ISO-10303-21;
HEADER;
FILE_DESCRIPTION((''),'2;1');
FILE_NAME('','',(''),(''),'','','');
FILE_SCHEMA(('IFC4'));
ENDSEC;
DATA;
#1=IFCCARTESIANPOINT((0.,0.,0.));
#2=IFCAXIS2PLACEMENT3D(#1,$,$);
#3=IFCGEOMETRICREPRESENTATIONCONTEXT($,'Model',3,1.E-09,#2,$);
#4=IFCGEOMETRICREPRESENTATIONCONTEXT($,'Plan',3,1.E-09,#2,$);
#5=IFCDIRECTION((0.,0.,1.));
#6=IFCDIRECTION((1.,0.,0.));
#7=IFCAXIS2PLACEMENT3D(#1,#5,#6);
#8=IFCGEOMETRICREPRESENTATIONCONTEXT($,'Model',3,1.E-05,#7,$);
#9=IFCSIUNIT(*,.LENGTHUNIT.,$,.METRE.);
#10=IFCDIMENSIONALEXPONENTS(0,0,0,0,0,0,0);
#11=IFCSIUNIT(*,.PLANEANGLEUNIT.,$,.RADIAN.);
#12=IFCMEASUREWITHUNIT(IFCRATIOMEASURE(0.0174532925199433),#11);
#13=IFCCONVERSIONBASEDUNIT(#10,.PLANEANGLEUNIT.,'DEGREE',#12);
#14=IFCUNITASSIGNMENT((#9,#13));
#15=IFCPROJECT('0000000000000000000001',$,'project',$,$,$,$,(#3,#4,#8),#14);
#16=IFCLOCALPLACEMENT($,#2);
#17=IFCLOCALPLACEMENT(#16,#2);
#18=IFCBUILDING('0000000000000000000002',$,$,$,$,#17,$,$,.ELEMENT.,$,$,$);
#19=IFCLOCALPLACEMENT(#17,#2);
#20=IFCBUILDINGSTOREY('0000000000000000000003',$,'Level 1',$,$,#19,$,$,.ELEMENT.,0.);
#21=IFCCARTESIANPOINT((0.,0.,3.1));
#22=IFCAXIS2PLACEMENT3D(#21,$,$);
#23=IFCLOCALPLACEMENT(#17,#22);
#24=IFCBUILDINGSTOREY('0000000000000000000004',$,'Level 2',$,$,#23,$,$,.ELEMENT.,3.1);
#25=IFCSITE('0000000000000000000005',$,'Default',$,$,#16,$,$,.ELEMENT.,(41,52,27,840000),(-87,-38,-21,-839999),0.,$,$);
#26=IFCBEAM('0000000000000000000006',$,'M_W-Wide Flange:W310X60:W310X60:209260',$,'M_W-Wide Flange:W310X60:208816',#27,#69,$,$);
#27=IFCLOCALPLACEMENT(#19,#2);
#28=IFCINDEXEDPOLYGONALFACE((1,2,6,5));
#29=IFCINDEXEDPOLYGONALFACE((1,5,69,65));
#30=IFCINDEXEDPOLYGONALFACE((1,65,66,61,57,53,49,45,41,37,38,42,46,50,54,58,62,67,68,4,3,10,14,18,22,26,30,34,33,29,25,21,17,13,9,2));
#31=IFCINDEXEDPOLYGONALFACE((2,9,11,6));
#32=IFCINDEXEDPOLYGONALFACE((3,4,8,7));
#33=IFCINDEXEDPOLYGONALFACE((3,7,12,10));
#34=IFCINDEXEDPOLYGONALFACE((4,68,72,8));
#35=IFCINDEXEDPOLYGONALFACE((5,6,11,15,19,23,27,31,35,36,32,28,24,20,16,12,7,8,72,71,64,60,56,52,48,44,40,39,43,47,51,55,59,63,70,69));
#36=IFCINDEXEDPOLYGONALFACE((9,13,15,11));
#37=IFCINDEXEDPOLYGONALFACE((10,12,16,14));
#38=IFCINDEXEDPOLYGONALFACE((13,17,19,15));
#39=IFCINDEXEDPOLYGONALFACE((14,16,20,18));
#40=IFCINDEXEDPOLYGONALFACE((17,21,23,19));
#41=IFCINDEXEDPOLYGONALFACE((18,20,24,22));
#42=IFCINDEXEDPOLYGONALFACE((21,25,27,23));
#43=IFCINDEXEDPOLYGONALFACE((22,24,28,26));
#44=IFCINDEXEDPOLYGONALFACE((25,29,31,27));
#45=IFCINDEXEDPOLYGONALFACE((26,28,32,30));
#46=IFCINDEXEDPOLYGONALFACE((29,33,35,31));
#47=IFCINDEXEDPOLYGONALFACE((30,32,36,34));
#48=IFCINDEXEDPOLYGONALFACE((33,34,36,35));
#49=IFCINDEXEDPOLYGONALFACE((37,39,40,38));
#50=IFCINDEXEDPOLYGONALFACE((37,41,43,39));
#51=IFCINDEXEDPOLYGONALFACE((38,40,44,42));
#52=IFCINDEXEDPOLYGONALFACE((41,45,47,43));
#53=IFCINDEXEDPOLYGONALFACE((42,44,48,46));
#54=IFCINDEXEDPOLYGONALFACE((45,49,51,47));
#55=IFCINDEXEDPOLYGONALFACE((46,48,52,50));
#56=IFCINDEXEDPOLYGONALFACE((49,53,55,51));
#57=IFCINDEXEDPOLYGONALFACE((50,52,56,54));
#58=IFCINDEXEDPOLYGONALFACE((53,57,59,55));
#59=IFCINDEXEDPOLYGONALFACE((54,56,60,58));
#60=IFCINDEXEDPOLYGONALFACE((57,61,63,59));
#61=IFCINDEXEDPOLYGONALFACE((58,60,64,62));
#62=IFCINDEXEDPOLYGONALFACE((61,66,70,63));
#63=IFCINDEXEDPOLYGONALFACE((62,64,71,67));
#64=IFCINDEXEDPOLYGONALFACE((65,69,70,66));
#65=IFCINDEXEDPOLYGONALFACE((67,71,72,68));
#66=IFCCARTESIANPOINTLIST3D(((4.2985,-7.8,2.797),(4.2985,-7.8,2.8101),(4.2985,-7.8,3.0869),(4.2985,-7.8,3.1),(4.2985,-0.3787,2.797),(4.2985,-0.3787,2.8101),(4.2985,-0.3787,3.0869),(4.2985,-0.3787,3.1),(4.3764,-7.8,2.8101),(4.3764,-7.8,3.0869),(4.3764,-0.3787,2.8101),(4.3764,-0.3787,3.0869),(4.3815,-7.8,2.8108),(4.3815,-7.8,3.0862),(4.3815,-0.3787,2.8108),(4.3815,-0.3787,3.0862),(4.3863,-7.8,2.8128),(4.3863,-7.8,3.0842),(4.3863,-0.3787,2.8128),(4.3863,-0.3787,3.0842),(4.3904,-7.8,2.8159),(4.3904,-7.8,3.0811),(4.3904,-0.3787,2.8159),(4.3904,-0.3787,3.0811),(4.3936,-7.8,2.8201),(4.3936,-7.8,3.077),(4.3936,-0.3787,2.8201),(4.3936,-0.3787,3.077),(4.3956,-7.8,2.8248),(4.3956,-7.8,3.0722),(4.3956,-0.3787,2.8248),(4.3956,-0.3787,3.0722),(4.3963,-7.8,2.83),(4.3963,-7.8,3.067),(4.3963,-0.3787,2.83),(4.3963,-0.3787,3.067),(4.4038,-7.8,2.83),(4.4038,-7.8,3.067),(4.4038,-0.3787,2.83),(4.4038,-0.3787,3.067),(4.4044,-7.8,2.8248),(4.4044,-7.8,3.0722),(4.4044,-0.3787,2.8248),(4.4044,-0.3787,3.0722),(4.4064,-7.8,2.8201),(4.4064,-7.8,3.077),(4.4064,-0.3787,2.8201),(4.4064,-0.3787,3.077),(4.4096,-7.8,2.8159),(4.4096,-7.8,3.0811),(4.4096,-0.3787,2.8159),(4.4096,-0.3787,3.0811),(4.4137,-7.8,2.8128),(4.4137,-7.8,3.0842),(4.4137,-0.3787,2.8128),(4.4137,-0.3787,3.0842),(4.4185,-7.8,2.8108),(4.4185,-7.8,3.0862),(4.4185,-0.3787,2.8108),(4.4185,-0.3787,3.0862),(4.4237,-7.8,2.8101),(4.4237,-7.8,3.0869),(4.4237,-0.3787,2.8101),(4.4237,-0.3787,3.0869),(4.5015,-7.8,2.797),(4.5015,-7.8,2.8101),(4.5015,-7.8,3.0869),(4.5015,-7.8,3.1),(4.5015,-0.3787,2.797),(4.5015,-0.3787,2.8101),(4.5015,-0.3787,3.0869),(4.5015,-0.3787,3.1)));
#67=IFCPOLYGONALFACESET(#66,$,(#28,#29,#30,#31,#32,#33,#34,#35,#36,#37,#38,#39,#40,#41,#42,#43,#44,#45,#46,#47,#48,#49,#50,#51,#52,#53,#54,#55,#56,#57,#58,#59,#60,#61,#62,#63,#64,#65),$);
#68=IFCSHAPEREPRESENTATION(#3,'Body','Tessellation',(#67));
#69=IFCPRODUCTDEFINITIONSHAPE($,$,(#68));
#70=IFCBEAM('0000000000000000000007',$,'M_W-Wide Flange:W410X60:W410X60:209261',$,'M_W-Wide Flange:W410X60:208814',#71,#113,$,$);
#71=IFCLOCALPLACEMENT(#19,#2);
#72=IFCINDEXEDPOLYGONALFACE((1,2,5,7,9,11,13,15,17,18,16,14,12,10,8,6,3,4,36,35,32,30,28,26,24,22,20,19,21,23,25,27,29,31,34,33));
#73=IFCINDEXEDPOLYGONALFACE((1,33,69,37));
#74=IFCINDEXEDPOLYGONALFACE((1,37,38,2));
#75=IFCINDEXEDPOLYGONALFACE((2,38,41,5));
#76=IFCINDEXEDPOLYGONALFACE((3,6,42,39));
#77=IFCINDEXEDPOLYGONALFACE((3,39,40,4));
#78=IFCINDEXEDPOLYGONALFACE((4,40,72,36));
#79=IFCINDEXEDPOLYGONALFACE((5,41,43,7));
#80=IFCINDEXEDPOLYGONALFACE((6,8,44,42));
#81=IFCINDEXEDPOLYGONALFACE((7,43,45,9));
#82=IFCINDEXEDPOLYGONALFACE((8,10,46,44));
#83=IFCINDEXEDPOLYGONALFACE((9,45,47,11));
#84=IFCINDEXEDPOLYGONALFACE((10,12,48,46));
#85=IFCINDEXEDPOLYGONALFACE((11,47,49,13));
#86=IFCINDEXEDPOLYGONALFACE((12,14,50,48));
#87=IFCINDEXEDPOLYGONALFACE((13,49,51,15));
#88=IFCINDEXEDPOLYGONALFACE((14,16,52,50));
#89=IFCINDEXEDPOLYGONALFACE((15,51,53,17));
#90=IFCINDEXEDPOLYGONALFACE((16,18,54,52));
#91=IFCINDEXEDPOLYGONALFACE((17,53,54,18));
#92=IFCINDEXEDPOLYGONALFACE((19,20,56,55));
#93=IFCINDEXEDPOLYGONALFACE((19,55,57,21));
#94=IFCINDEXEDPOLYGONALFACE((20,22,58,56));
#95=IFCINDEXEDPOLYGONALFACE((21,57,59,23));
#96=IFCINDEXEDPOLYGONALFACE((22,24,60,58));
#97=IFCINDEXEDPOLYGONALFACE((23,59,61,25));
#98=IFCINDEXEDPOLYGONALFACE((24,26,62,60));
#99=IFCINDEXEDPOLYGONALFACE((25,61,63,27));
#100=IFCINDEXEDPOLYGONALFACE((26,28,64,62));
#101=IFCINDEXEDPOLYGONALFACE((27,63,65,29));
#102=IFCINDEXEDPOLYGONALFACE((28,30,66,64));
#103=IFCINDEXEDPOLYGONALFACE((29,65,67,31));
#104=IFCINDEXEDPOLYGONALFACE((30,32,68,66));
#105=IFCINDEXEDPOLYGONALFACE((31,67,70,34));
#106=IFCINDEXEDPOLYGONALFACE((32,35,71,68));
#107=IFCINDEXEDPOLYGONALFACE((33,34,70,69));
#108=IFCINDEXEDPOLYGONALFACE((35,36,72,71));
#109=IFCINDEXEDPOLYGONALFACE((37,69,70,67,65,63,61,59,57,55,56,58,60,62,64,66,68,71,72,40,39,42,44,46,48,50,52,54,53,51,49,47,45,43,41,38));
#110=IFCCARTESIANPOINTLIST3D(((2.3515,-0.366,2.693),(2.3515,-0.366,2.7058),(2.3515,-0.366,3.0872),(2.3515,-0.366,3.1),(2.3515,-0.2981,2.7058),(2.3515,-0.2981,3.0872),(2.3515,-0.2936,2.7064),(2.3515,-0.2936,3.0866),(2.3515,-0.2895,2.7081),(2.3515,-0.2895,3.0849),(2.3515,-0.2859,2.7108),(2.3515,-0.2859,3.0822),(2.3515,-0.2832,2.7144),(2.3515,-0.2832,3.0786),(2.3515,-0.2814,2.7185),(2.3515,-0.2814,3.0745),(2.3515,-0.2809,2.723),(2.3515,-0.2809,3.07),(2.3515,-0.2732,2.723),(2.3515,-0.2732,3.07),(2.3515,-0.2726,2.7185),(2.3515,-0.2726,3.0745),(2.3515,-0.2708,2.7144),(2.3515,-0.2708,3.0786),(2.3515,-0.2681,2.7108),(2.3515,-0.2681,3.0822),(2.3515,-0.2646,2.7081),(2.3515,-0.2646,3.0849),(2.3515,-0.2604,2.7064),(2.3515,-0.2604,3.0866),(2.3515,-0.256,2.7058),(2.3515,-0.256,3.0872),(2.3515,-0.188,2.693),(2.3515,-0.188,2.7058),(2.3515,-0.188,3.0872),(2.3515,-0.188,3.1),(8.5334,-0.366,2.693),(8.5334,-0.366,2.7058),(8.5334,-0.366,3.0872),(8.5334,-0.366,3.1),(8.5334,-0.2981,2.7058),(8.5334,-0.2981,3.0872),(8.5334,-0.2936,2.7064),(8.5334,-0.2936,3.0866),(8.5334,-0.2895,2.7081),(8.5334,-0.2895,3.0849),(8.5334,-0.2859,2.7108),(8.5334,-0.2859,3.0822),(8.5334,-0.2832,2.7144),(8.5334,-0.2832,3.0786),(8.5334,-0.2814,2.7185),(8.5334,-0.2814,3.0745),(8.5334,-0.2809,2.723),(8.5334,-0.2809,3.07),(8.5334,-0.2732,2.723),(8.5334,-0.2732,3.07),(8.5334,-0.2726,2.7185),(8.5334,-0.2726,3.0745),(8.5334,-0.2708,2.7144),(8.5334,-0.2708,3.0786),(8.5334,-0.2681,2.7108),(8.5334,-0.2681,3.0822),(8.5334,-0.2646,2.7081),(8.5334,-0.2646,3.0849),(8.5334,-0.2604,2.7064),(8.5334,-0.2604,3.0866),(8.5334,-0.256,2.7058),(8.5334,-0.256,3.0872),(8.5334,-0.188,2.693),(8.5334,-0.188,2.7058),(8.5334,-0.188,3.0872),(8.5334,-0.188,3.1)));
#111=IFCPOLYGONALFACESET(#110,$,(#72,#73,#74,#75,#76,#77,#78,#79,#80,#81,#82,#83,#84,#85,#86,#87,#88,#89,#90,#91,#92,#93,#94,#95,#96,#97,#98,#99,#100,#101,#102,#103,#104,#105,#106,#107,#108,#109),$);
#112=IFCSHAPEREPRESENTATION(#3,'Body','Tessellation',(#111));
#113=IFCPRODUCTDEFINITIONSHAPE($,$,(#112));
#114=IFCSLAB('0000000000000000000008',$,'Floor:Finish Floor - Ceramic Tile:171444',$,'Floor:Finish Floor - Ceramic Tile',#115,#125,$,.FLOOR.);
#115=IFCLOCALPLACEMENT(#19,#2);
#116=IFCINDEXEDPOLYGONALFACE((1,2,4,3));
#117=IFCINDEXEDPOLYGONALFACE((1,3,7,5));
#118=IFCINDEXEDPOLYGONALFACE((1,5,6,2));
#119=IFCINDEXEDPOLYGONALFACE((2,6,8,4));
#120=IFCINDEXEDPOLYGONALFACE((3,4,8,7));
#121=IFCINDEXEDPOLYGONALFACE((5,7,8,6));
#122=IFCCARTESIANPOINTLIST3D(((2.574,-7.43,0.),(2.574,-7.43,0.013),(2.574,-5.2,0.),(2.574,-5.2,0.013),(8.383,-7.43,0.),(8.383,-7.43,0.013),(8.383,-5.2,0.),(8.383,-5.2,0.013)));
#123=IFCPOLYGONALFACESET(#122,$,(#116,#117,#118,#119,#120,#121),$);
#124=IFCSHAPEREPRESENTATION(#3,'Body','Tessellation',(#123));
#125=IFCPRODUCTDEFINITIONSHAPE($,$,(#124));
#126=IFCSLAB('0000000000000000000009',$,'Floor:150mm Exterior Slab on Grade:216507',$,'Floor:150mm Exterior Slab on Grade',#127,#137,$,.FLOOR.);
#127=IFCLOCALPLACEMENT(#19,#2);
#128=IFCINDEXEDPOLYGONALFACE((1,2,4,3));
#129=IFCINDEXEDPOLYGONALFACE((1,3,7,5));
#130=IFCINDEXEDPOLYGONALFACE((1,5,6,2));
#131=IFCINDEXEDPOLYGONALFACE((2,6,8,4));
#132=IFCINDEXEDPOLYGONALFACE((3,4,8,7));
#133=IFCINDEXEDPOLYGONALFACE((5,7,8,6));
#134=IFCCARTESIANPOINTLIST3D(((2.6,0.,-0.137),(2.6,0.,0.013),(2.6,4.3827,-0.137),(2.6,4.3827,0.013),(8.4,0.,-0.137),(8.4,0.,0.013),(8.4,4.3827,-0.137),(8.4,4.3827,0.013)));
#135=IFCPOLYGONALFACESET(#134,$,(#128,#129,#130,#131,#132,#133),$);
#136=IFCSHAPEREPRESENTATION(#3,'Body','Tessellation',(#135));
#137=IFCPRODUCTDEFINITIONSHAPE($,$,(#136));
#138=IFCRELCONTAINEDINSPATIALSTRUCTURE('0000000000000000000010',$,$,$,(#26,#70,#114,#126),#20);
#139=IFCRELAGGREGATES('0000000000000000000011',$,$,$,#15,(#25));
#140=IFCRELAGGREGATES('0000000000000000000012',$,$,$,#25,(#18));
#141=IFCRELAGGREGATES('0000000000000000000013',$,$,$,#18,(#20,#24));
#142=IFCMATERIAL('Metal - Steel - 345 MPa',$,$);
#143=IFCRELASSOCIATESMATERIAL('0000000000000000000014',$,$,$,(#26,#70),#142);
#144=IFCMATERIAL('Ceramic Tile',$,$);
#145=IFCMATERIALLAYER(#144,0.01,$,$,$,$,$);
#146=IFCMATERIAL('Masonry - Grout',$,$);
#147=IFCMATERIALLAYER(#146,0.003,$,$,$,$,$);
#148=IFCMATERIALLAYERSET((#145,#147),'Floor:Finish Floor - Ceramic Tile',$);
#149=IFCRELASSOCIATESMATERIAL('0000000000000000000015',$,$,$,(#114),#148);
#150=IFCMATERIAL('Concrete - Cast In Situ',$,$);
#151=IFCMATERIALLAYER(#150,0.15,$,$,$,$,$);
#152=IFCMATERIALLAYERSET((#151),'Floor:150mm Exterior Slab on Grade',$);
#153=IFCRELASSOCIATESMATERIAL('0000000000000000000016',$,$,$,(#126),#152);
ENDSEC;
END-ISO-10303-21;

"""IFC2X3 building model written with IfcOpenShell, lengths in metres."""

from ifc_helpers import new_model, entity, si_unit, converted_unit, frame, frame_2d, origin, origin_with_axes, place, context, project, spatial, polyline, circle_curve, parameter, trimmed, segment, composite_curve, rectangle, outline, extrude, material, layer, layer_set, layer_usage, element, save


model = new_model("IFC2X3")

# Units and contexts
model_context_1 = context("Model", 3, precision=1e-09, world=origin())
plan_context = context("Plan", 3, precision=1e-09, world=origin())
model_context_2 = context("Model", 3, precision=1e-05, world=origin_with_axes())
ifc_project = project(units=[si_unit("LENGTHUNIT", "METRE"), converted_unit("PLANEANGLEUNIT", "DEGREE", entity("IfcRatioMeasure", 0.0174532925199433), si_unit("PLANEANGLEUNIT", "RADIAN"), dimensions=[0, 0, 0, 0, 0, 0, 0])], contexts=[model_context_1, plan_context, model_context_2])

# Site, building, storey
site_placement = place(None, origin())
site = spatial("IfcSite", under=ifc_project, at=site_placement, Name="Default", CompositionType="ELEMENT", RefLatitude=(41, 52, 27, 840000), RefLongitude=(-87, -38, -21, -839999), RefElevation=0.0)
building_placement = place(site_placement, origin())
building = spatial("IfcBuilding", under=site, at=building_placement, CompositionType="ELEMENT")
storey_1_placement = place(building_placement, origin())
storey_1 = spatial("IfcBuildingStorey", under=building, at=storey_1_placement, Name="Level 1", CompositionType="ELEMENT", Elevation=0.0)

# Beams
ifc_material_1 = material(Name="Metal - Steel - 345 MPa")
beam_1_placement = place(storey_1_placement, frame((4.4, -7.8, 3.1)))
element("IfcBeam", 1, at=beam_1_placement, inside=storey_1, material=ifc_material_1, Name="M_W-Wide Flange:W310X60:W310X60:209260", ObjectType="M_W-Wide Flange:W310X60:208816", context=model_context_1, shape_type="SweptSolid", body=[
    extrude(outline(composite_curve([segment(polyline([(-0.1015, -0.1384), (-0.1015, -0.1515)]), True, "CONTINUOUS"), segment(polyline([(-0.1015, -0.1515), (0.1015, -0.1515)]), True, "CONTINUOUS"), segment(polyline([(0.1015, -0.1515), (0.1015, -0.1384)]), True, "CONTINUOUS"), segment(polyline([(0.1015, -0.1384), (0.0236, -0.1384)]), True, "CONTINUOUS"), segment(trimmed(circle_curve(frame_2d((0.0236, -0.1185), x_axis=(1.0, 0.0)), 0.0199), [parameter(180.0)], [parameter(270.0)], True, "PARAMETER"), False, "CONTINUOUS"), segment(polyline([(0.0037, -0.1185), (0.0037, 0.1185)]), True, "CONTINUOUS"), segment(trimmed(circle_curve(frame_2d((0.0236, 0.1185), x_axis=(1.0, 0.0)), 0.0199), [parameter(90.0)], [parameter(180.0)], True, "PARAMETER"), False, "CONTINUOUS"), segment(polyline([(0.0236, 0.1384), (0.1015, 0.1384)]), True, "CONTINUOUS"), segment(polyline([(0.1015, 0.1384), (0.1015, 0.1515)]), True, "CONTINUOUS"), segment(polyline([(0.1015, 0.1515), (-0.1015, 0.1515)]), True, "CONTINUOUS"), segment(polyline([(-0.1015, 0.1515), (-0.1015, 0.1384)]), True, "CONTINUOUS"), segment(polyline([(-0.1015, 0.1384), (-0.0237, 0.1384)]), True, "CONTINUOUS"), segment(trimmed(circle_curve(frame_2d((-0.0237, 0.1185), x_axis=(1.0, 0.0)), 0.0199), [parameter(360.0)], [parameter(90.0)], True, "PARAMETER"), False, "CONTINUOUS"), segment(polyline([(-0.0038, 0.1185), (-0.0038, -0.1185)]), True, "CONTINUOUS"), segment(trimmed(circle_curve(frame_2d((-0.0237, -0.1185), x_axis=(1.0, 0.0)), 0.0199), [parameter(270.0)], [parameter(0.0)], True, "PARAMETER"), False, "CONTINUOUS"), segment(polyline([(-0.0237, -0.1384), (-0.1015, -0.1384)]), True, "CONTINUOUS")], self_intersect=False)), frame((0.0, 0.0, -0.1515), z_axis=(0.0, -1.0, 0.0), x_axis=(1.0, 0.0, 0.0)), (0.0, 0.0, -1.0), 7.4213),
])
beam_2_placement = place(storey_1_placement, frame((8.5915, -0.277, 3.1), z_axis=(0.0, 0.0, 1.0), x_axis=(0.0, 1.0, 0.0)))
element("IfcBeam", 2, at=beam_2_placement, inside=storey_1, material=ifc_material_1, Name="M_W-Wide Flange:W410X60:W410X60:209261", ObjectType="M_W-Wide Flange:W410X60:208814", context=model_context_1, shape_type="SweptSolid", body=[
    extrude(outline(composite_curve([segment(polyline([(0.1907, -0.089), (0.2035, -0.089)]), True, "CONTINUOUS"), segment(polyline([(0.2035, -0.089), (0.2035, 0.089)]), True, "CONTINUOUS"), segment(polyline([(0.2035, 0.089), (0.1907, 0.089)]), True, "CONTINUOUS"), segment(polyline([(0.1907, 0.089), (0.1907, 0.021)]), True, "CONTINUOUS"), segment(trimmed(circle_curve(frame_2d((0.1735, 0.021), x_axis=(1.0, 0.0)), 0.0172), [parameter(270.0)], [parameter(360.0)], True, "PARAMETER"), False, "CONTINUOUS"), segment(polyline([(0.1735, 0.0038), (-0.1735, 0.0038)]), True, "CONTINUOUS"), segment(trimmed(circle_curve(frame_2d((-0.1735, 0.021), x_axis=(0.0, -1.0)), 0.0172), [parameter(270.0)], [parameter(360.0)], True, "PARAMETER"), False, "CONTINUOUS"), segment(polyline([(-0.1907, 0.021), (-0.1907, 0.089)]), True, "CONTINUOUS"), segment(polyline([(-0.1907, 0.089), (-0.2035, 0.089)]), True, "CONTINUOUS"), segment(polyline([(-0.2035, 0.089), (-0.2035, -0.089)]), True, "CONTINUOUS"), segment(polyline([(-0.2035, -0.089), (-0.1907, -0.089)]), True, "CONTINUOUS"), segment(polyline([(-0.1907, -0.089), (-0.1907, -0.0211)]), True, "CONTINUOUS"), segment(trimmed(circle_curve(frame_2d((-0.1735, -0.0211), x_axis=(-1.0, 0.0)), 0.0172), [parameter(270.0)], [parameter(0.0)], True, "PARAMETER"), False, "CONTINUOUS"), segment(polyline([(-0.1735, -0.0039), (0.1735, -0.0039)]), True, "CONTINUOUS"), segment(trimmed(circle_curve(frame_2d((0.1735, -0.0211), x_axis=(0.0, 1.0)), 0.0172), [parameter(270.0)], [parameter(0.0)], True, "PARAMETER"), False, "CONTINUOUS"), segment(polyline([(0.1907, -0.0211), (0.1907, -0.089)]), True, "CONTINUOUS")], self_intersect=False)), frame((0.0, 6.24, -0.2035), z_axis=(0.0, -1.0, 0.0), x_axis=(0.0, 0.0, -1.0)), (0.0, 0.0, 1.0), 6.1819),
])

# Slabs
ifc_material_2 = material(Name="Ceramic Tile")
ifc_layer_1 = layer(ifc_material_2, 0.01)
ifc_material_3 = material(Name="Masonry - Grout")
ifc_layer_2 = layer(ifc_material_3, 0.003)
ifc_layer_set_1 = layer_set([ifc_layer_1, ifc_layer_2], Name="Floor:Finish Floor - Ceramic Tile")
ifc_layer_usage_1 = layer_usage(ifc_layer_set_1, "AXIS3", "POSITIVE", 0.0)
slab_1_placement = place(storey_1_placement, frame((2.574, -7.43, 0.0)))
element("IfcSlab", 3, at=slab_1_placement, inside=storey_1, material=ifc_layer_usage_1, Name="Floor:Finish Floor - Ceramic Tile:171444", ObjectType="Floor:Finish Floor - Ceramic Tile", PredefinedType="FLOOR", context=model_context_1, shape_type="SweptSolid", body=[
    extrude(rectangle(XDim=5.809, YDim=2.23, at=frame_2d((0.0, 0.0), x_axis=(-1.0, 0.0))), frame((2.9045, 1.115, 0.013), z_axis=(0.0, 0.0, -1.0), x_axis=(-1.0, 0.0, 0.0)), (0.0, 0.0, 1.0), 0.013),
])
ifc_material_4 = material(Name="Concrete - Cast In Situ")
ifc_layer_3 = layer(ifc_material_4, 0.15)
ifc_layer_set_2 = layer_set([ifc_layer_3], Name="Floor:150mm Exterior Slab on Grade")
ifc_layer_usage_2 = layer_usage(ifc_layer_set_2, "AXIS3", "POSITIVE", 0.0)
slab_2_placement = place(storey_1_placement, frame((2.6, 0.0, -0.137)))
element("IfcSlab", 4, at=slab_2_placement, inside=storey_1, material=ifc_layer_usage_2, Name="Floor:150mm Exterior Slab on Grade:216507", ObjectType="Floor:150mm Exterior Slab on Grade", PredefinedType="FLOOR", context=model_context_1, shape_type="SweptSolid", body=[
    extrude(rectangle(XDim=5.8, YDim=4.3827, at=frame_2d((0.0, 0.0), x_axis=(-1.0, 0.0))), frame((2.9, 2.1914, 0.15), z_axis=(0.0, 0.0, -1.0), x_axis=(-1.0, 0.0, 0.0)), (0.0, 0.0, 1.0), 0.15),
])

# Shared definitions
storey_2_placement = place(building_placement, frame((0.0, 0.0, 3.1)))
storey_2 = spatial("IfcBuildingStorey", under=building, at=storey_2_placement, Name="Level 2", CompositionType="ELEMENT", Elevation=3.1)

save(model, "model.ifc")
